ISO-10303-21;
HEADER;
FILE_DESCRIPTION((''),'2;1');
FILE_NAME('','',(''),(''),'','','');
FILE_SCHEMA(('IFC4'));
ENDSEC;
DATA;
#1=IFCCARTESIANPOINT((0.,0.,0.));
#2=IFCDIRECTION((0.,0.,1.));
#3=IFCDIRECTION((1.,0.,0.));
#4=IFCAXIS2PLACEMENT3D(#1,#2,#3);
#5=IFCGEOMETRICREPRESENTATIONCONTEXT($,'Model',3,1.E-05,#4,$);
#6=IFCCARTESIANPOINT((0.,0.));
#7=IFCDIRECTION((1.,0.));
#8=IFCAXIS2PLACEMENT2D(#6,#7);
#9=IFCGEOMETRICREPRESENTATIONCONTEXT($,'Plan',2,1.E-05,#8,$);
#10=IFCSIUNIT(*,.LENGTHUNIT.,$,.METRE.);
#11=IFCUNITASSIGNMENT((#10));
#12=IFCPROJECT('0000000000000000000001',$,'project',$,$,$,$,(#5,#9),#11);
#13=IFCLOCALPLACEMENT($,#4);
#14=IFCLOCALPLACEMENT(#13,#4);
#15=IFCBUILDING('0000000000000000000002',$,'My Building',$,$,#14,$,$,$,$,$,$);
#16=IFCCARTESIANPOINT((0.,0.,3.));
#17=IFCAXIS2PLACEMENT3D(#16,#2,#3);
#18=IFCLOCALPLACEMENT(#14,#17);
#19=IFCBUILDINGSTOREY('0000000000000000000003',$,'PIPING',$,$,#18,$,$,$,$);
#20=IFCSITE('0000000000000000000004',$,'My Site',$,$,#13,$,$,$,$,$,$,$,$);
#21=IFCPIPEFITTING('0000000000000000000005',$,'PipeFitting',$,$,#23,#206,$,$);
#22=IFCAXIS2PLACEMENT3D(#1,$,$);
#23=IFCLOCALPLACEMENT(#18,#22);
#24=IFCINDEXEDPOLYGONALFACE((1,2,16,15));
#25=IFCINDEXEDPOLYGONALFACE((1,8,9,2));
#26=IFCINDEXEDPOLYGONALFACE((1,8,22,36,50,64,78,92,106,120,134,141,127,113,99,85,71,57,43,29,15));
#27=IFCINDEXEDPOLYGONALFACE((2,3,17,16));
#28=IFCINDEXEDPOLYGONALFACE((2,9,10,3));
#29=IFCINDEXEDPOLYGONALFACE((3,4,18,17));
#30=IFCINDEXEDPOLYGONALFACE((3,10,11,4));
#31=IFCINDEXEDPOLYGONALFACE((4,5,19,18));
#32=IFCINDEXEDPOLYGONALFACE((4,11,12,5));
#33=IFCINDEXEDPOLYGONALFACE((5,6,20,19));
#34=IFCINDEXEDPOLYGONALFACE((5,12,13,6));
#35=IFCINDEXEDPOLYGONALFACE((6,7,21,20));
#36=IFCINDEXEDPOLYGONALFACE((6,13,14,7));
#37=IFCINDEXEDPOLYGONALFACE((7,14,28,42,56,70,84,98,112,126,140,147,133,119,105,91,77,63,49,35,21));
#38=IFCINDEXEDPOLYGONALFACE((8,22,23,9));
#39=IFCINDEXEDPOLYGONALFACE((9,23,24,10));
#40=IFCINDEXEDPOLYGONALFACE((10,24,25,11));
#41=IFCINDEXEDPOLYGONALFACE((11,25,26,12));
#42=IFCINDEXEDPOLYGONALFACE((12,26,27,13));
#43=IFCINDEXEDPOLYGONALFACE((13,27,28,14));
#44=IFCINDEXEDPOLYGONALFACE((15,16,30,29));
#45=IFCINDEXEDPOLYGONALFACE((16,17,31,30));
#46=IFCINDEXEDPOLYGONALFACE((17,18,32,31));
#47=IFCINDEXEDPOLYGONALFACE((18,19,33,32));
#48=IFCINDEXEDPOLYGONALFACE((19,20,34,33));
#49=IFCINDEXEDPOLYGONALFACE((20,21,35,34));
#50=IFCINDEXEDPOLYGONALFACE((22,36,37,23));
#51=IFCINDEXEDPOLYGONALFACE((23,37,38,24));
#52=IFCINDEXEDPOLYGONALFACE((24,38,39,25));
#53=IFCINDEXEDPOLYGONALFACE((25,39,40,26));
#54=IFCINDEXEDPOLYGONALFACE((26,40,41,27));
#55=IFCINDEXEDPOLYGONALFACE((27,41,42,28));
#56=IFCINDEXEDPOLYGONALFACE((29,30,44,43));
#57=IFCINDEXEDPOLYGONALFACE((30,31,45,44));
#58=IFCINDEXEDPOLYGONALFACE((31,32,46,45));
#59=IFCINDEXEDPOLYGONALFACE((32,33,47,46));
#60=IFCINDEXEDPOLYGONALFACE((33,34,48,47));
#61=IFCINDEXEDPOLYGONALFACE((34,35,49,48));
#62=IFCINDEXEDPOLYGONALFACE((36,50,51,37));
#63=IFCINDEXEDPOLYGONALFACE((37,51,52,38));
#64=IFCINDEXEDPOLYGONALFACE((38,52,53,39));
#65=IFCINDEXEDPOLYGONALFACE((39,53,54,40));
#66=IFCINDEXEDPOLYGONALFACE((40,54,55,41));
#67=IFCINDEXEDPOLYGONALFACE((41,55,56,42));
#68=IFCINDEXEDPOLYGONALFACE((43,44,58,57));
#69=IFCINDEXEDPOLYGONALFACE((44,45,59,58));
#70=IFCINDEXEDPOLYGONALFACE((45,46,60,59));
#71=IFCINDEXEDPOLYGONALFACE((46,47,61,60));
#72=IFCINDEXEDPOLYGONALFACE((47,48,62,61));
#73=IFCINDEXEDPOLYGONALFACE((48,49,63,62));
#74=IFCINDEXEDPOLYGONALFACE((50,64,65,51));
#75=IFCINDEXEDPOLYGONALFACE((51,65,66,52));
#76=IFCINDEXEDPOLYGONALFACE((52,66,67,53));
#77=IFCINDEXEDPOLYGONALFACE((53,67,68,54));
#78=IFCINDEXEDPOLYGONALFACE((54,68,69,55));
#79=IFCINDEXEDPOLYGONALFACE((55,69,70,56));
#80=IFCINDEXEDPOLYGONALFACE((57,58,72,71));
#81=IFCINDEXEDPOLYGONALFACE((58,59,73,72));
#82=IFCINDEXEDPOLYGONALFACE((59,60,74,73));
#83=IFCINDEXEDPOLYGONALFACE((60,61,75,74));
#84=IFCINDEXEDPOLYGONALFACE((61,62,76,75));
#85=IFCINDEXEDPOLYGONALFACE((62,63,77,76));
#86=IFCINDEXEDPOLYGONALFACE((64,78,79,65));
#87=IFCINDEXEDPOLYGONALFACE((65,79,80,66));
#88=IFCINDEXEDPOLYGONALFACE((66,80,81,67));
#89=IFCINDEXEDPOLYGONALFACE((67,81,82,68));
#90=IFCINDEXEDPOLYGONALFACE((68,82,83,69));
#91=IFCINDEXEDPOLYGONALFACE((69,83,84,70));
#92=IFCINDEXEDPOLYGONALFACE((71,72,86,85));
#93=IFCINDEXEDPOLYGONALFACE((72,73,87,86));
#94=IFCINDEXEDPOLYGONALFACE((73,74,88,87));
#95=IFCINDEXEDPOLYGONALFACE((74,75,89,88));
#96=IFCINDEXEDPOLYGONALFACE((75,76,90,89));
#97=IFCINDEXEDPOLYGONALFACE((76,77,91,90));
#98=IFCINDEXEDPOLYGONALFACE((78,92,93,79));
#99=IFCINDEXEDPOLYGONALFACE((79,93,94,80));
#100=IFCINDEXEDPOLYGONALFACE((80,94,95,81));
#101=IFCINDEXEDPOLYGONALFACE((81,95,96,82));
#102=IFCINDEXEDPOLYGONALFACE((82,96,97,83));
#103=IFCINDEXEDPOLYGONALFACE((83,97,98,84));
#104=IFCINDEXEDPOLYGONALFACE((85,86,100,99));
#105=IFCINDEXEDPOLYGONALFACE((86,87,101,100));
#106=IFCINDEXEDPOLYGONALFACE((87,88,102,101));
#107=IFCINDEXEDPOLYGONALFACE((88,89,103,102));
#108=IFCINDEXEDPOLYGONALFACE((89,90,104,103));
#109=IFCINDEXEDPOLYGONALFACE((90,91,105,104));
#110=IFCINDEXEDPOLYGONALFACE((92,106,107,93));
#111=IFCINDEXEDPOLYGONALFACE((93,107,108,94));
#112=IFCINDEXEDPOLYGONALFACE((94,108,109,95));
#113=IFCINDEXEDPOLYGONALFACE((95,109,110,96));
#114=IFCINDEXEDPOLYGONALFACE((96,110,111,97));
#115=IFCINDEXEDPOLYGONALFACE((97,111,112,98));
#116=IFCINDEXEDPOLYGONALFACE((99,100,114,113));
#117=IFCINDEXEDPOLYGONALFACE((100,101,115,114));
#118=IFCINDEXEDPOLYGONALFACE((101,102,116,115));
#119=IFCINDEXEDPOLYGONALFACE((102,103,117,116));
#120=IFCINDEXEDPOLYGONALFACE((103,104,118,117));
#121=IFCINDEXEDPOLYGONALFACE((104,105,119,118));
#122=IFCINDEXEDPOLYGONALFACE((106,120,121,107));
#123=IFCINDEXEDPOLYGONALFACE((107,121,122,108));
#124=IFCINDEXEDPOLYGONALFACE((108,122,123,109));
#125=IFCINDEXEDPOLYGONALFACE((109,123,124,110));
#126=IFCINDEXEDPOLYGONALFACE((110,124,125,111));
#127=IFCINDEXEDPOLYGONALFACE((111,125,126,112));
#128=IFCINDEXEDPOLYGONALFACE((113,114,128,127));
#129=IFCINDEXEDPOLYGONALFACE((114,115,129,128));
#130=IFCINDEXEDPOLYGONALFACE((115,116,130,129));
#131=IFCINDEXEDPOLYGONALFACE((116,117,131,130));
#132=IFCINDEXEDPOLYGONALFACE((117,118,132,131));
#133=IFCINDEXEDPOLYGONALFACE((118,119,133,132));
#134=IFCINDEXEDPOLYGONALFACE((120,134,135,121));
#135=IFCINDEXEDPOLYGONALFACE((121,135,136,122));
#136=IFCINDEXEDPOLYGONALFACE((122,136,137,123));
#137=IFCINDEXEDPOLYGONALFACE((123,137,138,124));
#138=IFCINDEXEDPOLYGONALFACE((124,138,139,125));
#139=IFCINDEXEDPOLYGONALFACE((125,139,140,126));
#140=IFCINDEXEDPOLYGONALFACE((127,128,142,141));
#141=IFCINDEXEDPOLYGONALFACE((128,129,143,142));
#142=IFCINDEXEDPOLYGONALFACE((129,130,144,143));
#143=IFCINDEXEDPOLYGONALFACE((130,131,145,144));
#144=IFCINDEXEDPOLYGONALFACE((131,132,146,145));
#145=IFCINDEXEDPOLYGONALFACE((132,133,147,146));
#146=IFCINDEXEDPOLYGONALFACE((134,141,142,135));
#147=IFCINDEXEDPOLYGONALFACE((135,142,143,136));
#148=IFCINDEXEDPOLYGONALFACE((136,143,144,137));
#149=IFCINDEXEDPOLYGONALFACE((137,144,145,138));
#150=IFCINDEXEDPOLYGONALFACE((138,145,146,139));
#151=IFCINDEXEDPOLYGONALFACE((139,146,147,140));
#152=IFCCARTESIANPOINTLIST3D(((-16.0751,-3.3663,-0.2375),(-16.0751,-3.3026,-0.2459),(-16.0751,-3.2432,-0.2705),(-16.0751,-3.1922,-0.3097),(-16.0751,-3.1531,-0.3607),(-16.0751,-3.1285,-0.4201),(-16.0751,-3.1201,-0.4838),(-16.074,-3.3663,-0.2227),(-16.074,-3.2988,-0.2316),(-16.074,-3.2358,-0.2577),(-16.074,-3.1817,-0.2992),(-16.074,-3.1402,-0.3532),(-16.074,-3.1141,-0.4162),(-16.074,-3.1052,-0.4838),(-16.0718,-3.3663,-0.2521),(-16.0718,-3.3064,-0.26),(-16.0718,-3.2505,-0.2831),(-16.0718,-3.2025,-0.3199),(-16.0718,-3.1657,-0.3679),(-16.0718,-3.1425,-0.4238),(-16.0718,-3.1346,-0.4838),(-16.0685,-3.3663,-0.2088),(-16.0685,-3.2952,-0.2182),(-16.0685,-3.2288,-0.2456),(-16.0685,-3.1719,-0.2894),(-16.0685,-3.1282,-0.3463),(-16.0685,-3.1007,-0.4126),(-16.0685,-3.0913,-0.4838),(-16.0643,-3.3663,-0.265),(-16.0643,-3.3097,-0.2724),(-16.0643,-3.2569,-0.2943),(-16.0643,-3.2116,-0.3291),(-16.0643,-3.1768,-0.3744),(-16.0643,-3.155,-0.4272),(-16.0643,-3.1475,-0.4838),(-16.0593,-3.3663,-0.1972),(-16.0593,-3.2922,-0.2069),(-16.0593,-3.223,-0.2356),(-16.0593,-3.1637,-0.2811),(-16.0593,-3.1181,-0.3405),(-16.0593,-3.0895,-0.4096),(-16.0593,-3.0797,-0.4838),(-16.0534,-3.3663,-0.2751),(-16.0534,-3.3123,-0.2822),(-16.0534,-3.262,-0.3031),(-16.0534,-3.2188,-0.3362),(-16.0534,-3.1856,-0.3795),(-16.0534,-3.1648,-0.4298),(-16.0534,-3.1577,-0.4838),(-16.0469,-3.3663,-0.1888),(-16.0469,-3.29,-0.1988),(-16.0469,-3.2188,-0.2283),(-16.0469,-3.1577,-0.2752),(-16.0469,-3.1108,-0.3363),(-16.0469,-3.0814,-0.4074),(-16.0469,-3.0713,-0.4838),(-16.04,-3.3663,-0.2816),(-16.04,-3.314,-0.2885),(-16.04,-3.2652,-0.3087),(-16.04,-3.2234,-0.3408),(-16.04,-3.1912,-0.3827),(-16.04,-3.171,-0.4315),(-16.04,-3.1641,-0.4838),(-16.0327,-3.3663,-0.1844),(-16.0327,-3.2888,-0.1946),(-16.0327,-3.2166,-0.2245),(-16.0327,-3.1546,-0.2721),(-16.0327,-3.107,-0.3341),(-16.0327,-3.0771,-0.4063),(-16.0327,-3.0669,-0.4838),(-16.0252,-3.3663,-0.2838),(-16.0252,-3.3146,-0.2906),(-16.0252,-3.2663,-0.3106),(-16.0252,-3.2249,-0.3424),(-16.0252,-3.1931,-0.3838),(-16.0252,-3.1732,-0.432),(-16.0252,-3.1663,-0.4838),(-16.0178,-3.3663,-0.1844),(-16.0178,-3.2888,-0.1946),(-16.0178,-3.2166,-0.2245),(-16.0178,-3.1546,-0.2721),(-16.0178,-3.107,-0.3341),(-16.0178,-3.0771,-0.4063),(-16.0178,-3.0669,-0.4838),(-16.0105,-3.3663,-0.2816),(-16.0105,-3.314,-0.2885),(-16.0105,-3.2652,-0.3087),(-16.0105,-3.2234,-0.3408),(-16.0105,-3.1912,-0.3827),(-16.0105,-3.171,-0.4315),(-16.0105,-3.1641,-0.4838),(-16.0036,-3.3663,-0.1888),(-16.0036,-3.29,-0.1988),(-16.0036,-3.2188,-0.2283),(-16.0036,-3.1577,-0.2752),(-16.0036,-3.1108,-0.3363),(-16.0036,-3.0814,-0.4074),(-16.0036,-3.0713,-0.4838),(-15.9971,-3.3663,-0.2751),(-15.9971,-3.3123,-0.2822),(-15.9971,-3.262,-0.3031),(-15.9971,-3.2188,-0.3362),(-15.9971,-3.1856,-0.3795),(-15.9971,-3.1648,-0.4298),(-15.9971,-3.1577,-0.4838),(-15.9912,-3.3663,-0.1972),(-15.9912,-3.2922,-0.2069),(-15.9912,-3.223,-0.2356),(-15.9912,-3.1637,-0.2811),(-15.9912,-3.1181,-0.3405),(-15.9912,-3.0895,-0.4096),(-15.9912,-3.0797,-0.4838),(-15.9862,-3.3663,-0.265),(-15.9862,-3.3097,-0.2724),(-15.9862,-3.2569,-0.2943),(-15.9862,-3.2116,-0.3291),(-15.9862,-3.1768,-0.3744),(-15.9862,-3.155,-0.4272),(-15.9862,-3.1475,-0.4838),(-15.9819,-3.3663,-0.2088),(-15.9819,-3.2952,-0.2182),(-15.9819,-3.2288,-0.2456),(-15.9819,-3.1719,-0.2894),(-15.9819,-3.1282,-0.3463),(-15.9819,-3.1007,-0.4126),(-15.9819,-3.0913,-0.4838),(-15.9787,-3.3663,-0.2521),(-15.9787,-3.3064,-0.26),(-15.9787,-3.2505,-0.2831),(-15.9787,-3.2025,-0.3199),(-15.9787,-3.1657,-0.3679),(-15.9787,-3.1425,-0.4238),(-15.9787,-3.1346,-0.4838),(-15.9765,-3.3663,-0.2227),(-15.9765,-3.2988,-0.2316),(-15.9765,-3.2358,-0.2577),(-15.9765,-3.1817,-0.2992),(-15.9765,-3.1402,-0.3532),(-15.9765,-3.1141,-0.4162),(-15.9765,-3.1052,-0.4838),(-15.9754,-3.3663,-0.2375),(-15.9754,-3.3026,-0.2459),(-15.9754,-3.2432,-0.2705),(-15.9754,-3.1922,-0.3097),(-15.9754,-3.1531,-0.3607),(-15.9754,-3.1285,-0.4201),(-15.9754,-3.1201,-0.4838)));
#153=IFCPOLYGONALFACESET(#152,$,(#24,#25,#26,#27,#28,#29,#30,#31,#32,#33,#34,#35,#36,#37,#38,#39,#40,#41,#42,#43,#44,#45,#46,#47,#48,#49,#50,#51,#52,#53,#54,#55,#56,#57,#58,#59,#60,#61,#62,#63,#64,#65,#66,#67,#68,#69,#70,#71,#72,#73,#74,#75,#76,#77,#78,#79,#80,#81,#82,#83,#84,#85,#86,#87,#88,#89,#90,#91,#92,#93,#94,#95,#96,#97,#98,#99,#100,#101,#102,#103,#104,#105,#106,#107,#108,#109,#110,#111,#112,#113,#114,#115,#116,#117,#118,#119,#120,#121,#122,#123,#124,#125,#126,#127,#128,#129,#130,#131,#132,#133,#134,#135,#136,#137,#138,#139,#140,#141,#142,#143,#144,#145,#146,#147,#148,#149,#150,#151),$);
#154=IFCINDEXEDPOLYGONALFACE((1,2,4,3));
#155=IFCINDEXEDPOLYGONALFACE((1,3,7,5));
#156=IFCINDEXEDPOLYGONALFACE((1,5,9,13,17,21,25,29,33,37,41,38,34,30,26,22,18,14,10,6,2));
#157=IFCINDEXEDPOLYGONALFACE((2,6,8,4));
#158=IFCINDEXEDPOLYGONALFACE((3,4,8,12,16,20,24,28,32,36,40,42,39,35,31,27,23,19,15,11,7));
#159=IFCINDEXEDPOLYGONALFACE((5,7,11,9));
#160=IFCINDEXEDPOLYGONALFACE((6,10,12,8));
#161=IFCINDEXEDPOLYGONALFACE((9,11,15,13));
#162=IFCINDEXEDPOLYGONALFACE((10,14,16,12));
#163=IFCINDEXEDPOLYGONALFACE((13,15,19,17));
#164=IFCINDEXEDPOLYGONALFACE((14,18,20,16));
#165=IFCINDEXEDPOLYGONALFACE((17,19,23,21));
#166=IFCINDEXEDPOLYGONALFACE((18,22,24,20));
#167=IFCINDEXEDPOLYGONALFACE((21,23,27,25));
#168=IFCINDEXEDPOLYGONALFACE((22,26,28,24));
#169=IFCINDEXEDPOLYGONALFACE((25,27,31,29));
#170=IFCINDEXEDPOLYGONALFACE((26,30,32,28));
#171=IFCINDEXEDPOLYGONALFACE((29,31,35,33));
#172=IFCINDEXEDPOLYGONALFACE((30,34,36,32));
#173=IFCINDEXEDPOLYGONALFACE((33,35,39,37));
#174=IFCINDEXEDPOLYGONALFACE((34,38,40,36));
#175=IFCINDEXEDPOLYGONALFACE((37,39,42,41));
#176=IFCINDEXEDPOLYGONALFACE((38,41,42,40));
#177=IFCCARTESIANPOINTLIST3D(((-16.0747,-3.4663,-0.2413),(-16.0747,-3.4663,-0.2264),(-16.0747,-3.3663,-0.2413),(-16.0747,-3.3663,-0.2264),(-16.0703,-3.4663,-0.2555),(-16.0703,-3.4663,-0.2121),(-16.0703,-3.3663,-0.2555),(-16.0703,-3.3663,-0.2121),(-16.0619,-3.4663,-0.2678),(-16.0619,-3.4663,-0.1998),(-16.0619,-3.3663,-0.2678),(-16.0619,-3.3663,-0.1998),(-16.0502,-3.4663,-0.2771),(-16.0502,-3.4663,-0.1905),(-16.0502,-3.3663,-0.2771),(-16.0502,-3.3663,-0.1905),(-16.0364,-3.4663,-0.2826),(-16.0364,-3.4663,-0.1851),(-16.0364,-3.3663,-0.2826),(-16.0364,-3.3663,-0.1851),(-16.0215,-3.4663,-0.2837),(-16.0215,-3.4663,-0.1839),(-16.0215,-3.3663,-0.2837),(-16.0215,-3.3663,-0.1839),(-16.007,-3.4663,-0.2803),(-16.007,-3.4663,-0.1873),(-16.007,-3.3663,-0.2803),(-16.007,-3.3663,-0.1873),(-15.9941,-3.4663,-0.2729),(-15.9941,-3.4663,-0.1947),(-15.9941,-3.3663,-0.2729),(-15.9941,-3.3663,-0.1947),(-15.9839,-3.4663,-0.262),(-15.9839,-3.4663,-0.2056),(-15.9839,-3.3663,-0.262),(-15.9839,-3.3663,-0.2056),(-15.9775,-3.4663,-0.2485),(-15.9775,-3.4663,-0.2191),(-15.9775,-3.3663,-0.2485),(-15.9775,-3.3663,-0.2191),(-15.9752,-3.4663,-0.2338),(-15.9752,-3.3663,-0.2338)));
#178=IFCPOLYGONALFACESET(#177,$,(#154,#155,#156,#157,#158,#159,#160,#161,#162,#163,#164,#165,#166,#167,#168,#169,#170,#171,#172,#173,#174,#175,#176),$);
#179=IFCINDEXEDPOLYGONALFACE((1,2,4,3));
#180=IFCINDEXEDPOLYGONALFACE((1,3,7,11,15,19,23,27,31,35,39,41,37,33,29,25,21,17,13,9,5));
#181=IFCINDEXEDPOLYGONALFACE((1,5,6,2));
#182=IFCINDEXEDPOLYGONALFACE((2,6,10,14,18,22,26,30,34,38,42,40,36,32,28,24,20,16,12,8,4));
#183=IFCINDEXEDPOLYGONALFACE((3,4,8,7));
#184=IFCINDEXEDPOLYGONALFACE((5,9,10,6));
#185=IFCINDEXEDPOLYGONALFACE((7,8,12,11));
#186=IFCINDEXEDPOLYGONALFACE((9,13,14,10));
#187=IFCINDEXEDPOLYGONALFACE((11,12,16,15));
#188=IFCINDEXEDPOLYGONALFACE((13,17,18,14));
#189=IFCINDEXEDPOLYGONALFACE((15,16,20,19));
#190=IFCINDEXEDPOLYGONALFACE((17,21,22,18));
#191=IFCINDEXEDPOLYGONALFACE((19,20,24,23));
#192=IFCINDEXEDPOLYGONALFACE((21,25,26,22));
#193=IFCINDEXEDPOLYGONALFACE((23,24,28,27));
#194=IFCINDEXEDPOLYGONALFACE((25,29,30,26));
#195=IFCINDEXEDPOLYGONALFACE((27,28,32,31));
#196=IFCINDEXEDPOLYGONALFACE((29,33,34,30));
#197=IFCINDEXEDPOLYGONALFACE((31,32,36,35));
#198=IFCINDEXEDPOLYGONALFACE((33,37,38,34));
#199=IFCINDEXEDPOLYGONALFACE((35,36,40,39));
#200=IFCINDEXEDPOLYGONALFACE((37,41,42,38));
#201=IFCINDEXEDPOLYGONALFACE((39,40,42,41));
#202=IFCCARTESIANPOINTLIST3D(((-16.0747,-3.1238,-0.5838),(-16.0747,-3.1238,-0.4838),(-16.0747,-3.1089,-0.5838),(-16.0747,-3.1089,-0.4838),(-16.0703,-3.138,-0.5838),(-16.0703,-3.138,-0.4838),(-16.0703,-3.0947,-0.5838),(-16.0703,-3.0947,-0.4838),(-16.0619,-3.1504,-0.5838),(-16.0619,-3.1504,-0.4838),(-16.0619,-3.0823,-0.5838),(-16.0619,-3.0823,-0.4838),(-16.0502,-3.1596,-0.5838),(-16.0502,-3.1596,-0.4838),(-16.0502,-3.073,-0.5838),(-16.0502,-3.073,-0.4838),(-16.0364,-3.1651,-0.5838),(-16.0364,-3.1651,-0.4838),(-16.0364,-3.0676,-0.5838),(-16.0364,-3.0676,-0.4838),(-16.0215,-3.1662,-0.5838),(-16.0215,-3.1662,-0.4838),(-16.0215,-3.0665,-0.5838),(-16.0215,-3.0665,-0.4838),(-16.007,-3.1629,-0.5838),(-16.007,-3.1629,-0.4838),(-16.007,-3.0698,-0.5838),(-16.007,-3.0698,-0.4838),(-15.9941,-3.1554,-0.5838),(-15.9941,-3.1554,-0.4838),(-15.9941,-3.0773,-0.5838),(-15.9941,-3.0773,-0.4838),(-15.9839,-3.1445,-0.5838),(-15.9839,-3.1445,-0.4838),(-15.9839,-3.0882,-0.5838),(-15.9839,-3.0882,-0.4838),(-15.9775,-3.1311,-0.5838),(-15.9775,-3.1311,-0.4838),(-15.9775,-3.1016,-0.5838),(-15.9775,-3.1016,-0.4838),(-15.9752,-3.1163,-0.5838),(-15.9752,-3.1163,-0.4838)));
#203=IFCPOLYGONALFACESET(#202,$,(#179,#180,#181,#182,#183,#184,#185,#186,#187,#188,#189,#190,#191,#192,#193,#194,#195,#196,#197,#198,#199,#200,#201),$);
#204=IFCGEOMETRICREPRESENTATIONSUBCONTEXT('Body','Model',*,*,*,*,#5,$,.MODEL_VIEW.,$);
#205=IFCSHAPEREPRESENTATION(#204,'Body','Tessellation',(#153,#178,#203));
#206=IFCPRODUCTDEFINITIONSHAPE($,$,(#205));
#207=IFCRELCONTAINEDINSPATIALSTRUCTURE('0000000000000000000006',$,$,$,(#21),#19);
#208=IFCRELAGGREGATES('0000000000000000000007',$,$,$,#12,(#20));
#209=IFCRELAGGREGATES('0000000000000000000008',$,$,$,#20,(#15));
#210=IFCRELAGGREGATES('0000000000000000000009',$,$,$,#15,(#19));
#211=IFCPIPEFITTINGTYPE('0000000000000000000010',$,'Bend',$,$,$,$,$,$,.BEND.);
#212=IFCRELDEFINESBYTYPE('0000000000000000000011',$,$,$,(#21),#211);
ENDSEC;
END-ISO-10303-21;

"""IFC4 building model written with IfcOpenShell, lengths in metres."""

from ifc_helpers import new_model, entity, si_unit, frame, origin_with_axes, origin_2d_with_axis, place, context, subcontext, project, spatial, circle, extrude, source, transform, mapped, type_object, type_shapes, element, save


model = new_model("IFC4")

# Units and contexts
model_context = context("Model", 3, precision=1e-05, world=origin_with_axes())
plan_context = context("Plan", 2, precision=1e-05, world=origin_2d_with_axis())
body_context = subcontext(model_context, "Body", "Model", "MODEL_VIEW")
ifc_project = project(units=[si_unit("LENGTHUNIT", "METRE")], contexts=[model_context, plan_context])

# Site, building, storey
site_placement = place(None, origin_with_axes())
site = spatial("IfcSite", under=ifc_project, at=site_placement, Name="My Site")
building_placement = place(site_placement, origin_with_axes())
building = spatial("IfcBuilding", under=site, at=building_placement, Name="My Building")
storey_placement = place(building_placement, frame((0.0, 0.0, 3.0), z_axis=(0.0, 0.0, 1.0), x_axis=(1.0, 0.0, 0.0)))
storey = spatial("IfcBuildingStorey", under=building, at=storey_placement, Name="PIPING")

# Pipe fitting
pipe_fitting_type = type_object("IfcPipeFittingType", Name="Bend", PredefinedType="BEND")
shared_shape = source(origin_with_axes(), body_context, "Body", "SolidModel", [
    entity("IfcSweptDiskSolid", entity("IfcIndexedPolyCurve", entity("IfcCartesianPointList3D", [[0.0, 0.0, -0.1], [0.0, -0.0732, -0.2768], [0.0, -0.25, -0.35]]), [entity("IfcArcIndex", [1, 2, 3])]), 0.05),
    extrude(circle(Radius=0.05), origin_with_axes(), (0.0, 0.0, -1.0), 0.1),
    extrude(circle(Radius=0.05), frame((0.0, -0.25, -0.35), z_axis=(0.0, -1.0, 0.0), x_axis=(1.0, 0.0, 0.0)), (0.0, 0.0, 1.0), 0.1),
])
type_shapes(pipe_fitting_type, [shared_shape])
for number, where, z_axis, x_axis, name in (
    (1, (-16.0252, -3.4663, -0.2338), (0.0, -1.0, 0.0), (1.0, 0.0, 0.0), "PipeFitting"),
):
    element("IfcPipeFitting", number, at=place(storey_placement, frame(where, z_axis=z_axis, x_axis=x_axis)), inside=storey, type_object=pipe_fitting_type, Name=name, context=body_context, shape_type="MappedRepresentation", body=[
        mapped(shared_shape, transform((0.0, 0.0, 0.0), x_axis=(1.0, 0.0, 0.0), y_axis=(0.0, 1.0, 0.0), z_axis=(0.0, 0.0, 1.0), scale=1.0)),
    ])

save(model, "model.ifc")
